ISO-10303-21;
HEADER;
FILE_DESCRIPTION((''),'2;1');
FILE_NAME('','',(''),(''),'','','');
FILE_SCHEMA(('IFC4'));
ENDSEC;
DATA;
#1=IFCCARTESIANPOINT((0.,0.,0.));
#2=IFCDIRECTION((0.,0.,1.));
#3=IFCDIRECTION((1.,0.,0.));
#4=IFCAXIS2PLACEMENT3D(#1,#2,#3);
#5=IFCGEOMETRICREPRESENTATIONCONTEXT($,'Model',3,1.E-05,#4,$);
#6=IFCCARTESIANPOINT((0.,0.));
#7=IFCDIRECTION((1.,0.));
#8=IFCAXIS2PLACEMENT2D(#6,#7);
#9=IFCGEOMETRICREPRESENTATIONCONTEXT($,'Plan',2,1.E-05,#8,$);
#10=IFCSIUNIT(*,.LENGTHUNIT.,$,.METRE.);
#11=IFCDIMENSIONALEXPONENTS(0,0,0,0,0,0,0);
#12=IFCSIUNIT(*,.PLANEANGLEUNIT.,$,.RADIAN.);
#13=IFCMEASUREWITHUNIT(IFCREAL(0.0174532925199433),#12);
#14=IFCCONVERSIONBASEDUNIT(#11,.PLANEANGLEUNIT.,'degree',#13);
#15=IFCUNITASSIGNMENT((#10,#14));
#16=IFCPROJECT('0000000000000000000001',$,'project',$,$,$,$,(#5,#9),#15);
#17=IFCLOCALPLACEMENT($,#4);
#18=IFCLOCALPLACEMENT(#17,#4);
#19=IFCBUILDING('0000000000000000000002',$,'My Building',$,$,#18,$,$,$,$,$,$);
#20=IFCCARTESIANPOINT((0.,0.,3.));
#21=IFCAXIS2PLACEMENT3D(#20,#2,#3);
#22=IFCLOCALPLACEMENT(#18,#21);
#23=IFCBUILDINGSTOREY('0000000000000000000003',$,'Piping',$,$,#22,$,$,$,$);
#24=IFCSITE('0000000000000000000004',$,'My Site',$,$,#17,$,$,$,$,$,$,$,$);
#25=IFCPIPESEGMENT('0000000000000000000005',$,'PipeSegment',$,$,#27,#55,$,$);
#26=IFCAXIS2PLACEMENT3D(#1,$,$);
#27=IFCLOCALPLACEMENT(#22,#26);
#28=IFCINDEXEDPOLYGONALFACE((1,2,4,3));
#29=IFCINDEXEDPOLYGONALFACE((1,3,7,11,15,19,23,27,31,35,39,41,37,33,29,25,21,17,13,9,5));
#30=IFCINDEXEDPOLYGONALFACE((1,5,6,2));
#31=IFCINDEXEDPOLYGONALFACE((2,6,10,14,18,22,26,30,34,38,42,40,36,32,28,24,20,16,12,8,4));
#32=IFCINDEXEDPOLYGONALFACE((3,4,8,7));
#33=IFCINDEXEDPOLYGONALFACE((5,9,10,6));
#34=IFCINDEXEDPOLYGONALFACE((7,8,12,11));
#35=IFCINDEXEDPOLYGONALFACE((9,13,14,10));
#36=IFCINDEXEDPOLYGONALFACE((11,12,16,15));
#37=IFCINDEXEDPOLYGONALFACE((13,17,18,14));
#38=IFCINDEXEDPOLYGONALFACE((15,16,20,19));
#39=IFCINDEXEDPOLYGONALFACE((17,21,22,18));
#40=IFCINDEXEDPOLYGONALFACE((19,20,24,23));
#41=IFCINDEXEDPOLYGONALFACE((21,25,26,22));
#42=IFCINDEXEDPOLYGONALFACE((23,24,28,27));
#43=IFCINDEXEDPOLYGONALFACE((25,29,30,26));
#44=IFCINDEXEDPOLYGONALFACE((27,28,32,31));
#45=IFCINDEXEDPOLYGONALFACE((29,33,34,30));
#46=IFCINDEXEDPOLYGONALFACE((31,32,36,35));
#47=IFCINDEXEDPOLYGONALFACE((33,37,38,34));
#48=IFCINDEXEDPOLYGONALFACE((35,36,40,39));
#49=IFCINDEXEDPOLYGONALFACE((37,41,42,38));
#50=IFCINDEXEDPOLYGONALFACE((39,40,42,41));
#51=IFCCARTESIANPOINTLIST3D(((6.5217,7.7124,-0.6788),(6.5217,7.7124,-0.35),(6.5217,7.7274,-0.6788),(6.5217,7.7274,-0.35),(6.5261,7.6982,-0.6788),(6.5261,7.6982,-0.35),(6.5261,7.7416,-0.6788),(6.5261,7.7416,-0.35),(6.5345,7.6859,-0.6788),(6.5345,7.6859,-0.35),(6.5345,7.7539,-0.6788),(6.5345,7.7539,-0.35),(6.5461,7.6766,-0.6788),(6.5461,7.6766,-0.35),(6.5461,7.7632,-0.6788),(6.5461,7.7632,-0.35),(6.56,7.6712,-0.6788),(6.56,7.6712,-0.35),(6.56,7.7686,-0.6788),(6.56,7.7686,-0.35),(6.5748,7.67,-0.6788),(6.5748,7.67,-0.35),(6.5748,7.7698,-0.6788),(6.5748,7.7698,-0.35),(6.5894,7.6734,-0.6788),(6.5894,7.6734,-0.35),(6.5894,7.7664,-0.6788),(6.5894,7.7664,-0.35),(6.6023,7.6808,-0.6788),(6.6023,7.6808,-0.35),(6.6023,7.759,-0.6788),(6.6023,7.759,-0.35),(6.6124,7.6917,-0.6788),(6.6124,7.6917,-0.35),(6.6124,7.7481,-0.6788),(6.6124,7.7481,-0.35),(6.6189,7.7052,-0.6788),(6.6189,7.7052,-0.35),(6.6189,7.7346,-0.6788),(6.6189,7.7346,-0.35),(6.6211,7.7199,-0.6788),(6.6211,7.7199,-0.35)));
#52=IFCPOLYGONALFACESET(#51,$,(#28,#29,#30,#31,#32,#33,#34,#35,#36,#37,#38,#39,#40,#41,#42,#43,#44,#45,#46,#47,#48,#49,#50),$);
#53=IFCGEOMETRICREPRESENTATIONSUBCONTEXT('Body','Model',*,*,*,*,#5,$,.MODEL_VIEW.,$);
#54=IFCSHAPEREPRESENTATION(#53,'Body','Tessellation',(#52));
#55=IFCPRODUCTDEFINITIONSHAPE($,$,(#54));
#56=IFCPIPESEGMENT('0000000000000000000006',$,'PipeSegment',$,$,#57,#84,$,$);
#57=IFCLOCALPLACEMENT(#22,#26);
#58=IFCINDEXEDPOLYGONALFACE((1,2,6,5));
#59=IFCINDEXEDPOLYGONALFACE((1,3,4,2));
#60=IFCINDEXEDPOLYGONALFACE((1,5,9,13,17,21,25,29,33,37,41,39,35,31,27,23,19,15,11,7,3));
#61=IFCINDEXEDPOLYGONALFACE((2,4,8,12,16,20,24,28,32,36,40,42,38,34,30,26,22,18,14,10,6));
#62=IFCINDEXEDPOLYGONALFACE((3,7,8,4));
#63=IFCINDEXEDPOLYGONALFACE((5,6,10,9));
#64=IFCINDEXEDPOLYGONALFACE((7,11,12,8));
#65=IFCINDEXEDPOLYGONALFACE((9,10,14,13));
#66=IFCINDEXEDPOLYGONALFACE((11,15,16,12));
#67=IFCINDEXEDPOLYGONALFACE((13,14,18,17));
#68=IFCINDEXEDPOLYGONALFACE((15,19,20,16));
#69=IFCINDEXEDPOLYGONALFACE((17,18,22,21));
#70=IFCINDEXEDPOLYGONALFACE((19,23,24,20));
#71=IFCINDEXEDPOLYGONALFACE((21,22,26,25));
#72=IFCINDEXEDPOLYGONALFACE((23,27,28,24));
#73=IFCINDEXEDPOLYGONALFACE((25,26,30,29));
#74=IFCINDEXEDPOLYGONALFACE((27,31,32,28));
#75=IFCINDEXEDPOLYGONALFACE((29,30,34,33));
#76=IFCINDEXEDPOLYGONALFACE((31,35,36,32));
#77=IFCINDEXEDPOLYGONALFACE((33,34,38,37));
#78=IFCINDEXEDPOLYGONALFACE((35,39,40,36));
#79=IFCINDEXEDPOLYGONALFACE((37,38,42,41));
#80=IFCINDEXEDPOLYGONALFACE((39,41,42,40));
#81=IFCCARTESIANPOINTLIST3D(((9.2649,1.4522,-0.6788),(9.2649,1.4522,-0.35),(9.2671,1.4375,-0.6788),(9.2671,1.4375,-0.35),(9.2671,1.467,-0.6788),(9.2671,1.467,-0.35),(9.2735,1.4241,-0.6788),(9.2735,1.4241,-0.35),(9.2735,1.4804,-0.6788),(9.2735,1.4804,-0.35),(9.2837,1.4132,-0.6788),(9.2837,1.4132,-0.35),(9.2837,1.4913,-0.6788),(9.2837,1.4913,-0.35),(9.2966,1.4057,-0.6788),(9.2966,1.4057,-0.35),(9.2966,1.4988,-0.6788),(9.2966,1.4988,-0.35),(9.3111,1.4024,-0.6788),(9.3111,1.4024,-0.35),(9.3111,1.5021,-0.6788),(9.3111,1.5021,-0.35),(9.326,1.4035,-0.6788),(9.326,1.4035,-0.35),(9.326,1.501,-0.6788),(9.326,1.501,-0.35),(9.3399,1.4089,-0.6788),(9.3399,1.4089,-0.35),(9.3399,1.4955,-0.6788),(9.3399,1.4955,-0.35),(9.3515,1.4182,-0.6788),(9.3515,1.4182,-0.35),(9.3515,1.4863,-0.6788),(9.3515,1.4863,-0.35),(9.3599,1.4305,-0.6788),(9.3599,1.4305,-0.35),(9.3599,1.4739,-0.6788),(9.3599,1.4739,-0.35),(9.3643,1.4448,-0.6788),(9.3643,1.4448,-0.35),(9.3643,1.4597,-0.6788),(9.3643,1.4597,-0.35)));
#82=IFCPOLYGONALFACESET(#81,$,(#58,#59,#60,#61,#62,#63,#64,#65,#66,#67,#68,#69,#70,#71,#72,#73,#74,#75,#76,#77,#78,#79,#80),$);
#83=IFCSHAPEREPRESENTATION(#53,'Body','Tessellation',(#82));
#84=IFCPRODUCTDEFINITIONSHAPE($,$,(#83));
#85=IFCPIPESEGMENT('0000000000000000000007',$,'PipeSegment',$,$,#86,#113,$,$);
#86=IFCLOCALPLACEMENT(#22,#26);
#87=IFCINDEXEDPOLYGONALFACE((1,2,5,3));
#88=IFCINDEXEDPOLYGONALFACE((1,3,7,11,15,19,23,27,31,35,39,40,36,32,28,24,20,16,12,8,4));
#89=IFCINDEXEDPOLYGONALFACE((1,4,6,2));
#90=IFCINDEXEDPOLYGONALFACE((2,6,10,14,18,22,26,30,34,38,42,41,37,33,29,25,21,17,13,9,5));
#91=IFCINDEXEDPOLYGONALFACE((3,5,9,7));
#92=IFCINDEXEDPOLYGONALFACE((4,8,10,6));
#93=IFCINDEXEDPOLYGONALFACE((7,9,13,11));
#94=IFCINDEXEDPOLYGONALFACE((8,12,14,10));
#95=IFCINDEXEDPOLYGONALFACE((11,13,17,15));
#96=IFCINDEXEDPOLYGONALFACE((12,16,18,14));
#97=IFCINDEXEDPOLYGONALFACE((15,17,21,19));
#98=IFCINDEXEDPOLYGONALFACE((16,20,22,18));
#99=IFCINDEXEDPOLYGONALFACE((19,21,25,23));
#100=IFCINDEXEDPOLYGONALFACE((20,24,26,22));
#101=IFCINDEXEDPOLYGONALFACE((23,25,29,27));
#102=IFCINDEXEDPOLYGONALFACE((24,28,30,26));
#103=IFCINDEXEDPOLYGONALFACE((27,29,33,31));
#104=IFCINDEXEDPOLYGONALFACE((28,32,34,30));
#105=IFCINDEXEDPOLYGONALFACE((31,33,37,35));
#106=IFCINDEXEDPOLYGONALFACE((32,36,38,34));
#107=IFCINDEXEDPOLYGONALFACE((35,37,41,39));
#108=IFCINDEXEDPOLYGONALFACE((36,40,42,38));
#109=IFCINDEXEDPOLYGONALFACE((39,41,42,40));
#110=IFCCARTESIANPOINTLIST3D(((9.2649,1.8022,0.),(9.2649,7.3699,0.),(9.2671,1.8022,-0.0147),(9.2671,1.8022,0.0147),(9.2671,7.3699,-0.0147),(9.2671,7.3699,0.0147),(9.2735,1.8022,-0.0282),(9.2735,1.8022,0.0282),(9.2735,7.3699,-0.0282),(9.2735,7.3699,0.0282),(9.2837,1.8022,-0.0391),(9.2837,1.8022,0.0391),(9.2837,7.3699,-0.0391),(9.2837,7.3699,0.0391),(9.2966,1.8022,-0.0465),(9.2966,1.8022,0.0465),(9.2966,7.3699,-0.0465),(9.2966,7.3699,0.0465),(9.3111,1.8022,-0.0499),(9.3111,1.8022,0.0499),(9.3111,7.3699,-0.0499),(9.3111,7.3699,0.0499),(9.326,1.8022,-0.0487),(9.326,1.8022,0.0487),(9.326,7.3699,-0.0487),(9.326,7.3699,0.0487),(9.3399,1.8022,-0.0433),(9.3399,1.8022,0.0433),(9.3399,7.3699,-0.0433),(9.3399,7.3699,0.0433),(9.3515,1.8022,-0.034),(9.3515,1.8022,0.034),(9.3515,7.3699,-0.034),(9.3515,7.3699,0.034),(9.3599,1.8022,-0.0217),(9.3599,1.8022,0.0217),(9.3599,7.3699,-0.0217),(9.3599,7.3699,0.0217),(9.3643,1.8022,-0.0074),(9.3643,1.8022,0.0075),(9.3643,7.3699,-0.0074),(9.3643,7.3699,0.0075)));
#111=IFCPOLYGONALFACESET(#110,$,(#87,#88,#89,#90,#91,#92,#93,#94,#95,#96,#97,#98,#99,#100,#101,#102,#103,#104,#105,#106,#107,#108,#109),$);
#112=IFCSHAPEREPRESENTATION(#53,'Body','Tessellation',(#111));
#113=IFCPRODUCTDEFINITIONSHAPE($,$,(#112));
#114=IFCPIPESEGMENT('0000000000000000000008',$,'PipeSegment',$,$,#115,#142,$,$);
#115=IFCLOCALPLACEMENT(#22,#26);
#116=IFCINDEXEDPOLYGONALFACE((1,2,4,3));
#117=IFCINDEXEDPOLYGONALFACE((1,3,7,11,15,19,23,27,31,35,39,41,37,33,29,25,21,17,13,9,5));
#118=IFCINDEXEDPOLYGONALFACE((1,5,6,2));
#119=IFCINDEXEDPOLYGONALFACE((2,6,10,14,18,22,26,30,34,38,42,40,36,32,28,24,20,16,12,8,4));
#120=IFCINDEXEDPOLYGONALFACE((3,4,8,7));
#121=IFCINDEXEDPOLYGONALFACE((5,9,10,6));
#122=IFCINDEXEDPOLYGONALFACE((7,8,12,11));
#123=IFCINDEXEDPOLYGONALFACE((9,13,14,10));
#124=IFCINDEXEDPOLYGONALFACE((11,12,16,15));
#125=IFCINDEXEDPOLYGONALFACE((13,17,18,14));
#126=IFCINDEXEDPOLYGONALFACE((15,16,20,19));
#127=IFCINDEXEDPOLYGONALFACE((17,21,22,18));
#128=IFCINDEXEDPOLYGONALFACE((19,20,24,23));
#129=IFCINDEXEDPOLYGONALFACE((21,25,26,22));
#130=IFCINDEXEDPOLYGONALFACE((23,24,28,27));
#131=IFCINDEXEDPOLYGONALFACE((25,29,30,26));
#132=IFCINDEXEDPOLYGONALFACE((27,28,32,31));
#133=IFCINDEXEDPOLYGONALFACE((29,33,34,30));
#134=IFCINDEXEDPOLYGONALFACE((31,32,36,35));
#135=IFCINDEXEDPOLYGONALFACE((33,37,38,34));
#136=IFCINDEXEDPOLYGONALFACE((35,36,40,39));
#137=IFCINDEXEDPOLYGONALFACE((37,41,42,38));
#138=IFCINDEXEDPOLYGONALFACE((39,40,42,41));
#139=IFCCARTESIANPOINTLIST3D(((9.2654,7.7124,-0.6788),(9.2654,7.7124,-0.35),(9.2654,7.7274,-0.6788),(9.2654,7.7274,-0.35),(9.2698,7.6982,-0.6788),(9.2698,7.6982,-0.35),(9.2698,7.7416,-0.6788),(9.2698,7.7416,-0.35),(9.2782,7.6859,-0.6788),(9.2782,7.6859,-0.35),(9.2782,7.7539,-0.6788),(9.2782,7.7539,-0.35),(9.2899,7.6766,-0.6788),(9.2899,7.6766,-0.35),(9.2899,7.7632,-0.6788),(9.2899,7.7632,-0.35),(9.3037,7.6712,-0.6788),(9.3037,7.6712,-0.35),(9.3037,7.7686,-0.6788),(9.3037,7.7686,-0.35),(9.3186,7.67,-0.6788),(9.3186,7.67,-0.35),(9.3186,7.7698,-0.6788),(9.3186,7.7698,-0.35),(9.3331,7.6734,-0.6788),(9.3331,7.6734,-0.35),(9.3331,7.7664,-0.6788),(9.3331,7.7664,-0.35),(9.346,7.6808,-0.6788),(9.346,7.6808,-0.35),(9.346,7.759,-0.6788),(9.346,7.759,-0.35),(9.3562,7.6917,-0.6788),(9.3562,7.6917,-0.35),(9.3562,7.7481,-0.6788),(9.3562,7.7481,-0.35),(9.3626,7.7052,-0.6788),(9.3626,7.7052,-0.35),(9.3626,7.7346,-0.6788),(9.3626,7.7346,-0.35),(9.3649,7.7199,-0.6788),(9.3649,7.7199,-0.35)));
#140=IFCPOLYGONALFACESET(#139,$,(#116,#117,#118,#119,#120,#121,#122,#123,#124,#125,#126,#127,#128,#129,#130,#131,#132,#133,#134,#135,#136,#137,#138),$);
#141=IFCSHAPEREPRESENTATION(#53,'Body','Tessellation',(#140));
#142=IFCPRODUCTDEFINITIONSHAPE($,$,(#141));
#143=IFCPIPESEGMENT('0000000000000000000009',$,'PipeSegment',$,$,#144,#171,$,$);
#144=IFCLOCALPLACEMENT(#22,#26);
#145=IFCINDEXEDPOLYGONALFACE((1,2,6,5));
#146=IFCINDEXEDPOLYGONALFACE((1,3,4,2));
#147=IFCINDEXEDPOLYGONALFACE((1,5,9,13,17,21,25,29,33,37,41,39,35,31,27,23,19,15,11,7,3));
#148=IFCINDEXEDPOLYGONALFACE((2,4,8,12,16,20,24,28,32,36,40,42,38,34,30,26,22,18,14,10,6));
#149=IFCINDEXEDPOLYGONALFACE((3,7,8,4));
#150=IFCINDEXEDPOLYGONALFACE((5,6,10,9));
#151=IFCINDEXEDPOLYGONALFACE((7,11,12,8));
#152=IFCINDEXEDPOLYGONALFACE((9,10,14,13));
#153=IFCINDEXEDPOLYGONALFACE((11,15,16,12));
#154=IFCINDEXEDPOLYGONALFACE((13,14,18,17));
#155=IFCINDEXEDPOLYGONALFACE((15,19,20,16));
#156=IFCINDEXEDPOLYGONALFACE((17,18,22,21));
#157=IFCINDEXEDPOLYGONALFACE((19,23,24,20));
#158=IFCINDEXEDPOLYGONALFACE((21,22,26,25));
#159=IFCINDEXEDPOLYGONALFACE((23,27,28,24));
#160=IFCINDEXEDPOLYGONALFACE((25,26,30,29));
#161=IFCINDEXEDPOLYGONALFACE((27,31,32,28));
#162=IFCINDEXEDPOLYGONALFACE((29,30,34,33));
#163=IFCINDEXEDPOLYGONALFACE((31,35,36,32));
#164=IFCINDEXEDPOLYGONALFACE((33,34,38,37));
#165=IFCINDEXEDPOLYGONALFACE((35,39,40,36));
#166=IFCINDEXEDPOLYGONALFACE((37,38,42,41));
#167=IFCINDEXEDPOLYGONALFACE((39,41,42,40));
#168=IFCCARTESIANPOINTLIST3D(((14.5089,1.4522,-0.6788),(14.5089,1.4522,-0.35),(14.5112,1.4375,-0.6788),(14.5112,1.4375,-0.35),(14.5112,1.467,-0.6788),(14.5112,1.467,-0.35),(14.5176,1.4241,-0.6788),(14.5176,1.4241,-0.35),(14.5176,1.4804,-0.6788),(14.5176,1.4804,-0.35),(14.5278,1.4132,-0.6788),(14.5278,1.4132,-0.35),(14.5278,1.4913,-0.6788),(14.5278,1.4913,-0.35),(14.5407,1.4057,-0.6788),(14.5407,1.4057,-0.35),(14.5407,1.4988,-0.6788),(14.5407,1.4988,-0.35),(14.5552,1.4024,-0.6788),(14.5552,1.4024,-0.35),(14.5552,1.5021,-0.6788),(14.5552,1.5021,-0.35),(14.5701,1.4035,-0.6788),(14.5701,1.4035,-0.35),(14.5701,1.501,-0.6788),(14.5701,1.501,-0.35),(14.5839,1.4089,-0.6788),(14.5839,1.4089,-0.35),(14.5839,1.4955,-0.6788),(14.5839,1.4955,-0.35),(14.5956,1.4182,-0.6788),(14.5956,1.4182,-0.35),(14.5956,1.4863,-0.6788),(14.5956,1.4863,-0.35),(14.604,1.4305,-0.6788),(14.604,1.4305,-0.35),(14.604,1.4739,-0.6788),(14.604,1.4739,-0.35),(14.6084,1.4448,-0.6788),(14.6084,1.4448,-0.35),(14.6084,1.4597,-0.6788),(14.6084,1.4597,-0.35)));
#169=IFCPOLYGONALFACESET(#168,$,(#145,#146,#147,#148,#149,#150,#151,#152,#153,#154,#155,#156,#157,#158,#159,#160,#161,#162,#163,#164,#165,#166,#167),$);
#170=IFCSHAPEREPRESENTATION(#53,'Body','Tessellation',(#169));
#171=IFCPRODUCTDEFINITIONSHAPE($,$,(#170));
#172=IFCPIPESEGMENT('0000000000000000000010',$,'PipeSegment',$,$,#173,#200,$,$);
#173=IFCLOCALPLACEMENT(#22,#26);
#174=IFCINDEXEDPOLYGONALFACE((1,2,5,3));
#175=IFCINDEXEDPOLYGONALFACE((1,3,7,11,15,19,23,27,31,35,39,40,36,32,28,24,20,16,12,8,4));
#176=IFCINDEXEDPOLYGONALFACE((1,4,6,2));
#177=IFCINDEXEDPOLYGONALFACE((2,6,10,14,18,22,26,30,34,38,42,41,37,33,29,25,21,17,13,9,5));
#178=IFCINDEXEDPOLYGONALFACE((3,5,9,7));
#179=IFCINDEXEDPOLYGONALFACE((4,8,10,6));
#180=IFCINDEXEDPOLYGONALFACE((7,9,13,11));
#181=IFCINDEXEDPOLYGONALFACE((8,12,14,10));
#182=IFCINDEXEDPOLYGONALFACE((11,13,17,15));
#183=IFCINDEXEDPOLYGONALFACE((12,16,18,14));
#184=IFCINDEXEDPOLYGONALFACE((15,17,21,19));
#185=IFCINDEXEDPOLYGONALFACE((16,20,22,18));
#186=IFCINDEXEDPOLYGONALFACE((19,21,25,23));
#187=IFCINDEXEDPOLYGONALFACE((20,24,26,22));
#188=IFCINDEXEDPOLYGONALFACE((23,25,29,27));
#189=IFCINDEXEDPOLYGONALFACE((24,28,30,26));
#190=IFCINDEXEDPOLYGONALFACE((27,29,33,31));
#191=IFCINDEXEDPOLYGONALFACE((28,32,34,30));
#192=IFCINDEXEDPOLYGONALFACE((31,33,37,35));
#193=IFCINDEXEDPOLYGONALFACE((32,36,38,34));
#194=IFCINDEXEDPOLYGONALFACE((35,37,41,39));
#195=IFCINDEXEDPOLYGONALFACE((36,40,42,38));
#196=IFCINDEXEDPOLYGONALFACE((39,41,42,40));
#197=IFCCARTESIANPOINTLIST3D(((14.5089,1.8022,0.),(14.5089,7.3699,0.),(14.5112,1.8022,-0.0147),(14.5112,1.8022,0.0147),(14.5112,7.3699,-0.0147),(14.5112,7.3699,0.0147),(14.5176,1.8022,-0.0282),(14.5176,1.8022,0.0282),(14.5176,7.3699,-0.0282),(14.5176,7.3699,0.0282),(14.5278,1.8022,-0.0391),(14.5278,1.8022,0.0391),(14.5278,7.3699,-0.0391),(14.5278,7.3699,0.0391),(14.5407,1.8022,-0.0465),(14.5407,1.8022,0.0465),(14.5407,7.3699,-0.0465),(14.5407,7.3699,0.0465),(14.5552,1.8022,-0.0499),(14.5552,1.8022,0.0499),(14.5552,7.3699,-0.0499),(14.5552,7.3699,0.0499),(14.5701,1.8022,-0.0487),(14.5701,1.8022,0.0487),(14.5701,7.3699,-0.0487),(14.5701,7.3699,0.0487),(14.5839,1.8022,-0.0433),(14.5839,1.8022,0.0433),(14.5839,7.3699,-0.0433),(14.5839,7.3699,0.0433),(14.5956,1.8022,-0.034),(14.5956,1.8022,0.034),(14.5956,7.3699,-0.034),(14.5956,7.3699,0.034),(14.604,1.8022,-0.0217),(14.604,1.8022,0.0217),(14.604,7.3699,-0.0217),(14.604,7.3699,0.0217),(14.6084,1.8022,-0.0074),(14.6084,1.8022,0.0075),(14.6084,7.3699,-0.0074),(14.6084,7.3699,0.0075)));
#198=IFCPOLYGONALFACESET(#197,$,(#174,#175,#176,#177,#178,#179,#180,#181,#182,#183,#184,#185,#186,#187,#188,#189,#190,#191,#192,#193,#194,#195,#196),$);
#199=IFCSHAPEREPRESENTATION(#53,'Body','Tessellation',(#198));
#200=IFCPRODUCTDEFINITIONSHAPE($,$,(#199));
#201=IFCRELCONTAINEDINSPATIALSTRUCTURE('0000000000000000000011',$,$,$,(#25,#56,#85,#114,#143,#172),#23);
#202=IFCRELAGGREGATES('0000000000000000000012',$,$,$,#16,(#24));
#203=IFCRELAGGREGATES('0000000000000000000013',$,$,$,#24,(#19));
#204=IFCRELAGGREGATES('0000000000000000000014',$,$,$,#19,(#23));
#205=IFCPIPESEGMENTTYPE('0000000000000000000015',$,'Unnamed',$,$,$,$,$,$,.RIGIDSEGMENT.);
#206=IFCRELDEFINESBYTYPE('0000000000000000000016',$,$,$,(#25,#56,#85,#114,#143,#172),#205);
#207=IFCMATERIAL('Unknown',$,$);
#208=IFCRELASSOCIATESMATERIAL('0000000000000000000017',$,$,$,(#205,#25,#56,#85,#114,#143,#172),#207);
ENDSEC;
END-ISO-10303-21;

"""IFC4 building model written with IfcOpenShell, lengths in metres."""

from ifc_helpers import new_model, entity, si_unit, converted_unit, frame, origin_with_axes, origin_2d_with_axis, place, context, subcontext, project, spatial, circle, extrude, material, material_profile, profile_set, profile_usage, type_object, element, save


model = new_model("IFC4")

# Units and contexts
model_context = context("Model", 3, precision=1e-05, world=origin_with_axes())
plan_context = context("Plan", 2, precision=1e-05, world=origin_2d_with_axis())
body_context = subcontext(model_context, "Body", "Model", "MODEL_VIEW")
ifc_project = project(units=[si_unit("LENGTHUNIT", "METRE"), converted_unit("PLANEANGLEUNIT", "degree", entity("IfcReal", 0.0174532925199433), si_unit("PLANEANGLEUNIT", "RADIAN"), dimensions=[0, 0, 0, 0, 0, 0, 0])], contexts=[model_context, plan_context])

# Site, building, storey
site_placement = place(None, origin_with_axes())
site = spatial("IfcSite", under=ifc_project, at=site_placement, Name="My Site")
building_placement = place(site_placement, origin_with_axes())
building = spatial("IfcBuilding", under=site, at=building_placement, Name="My Building")
storey_placement = place(building_placement, frame((0.0, 0.0, 3.0), z_axis=(0.0, 0.0, 1.0), x_axis=(1.0, 0.0, 0.0)))
storey = spatial("IfcBuildingStorey", under=building, at=storey_placement, Name="Piping")

# Pipe segments
ifc_material = material(Name="Unknown")
ifc_material_profile = material_profile(ifc_material, circle(Radius=0.05))
ifc_profile_set = profile_set([ifc_material_profile])
pipe_segment_type = type_object("IfcPipeSegmentType", Name="Unnamed", PredefinedType="RIGIDSEGMENT", material=ifc_profile_set)
ifc_profile_usage_1 = profile_usage(ifc_profile_set, cardinal=5)
pipe_segment_1_placement = place(storey_placement, frame((6.5711, 7.7199, -0.6788), z_axis=(0.0, 0.0, 1.0), x_axis=(1.0, 0.0, 0.0)))
element("IfcPipeSegment", 1, at=pipe_segment_1_placement, inside=storey, type_object=pipe_segment_type, material=ifc_profile_usage_1, Name="PipeSegment", context=body_context, shape_type="SweptSolid", body=[
    extrude(circle(Radius=0.05), origin_with_axes(), (0.0, 0.0, 1.0), 0.3288),
])
ifc_profile_usage_2 = profile_usage(ifc_profile_set, cardinal=5)
pipe_segment_2_placement = place(storey_placement, frame((9.3149, 1.4522, -0.35), z_axis=(0.0, 0.0, -1.0), x_axis=(-1.0, 0.0, 0.0)))
element("IfcPipeSegment", 2, at=pipe_segment_2_placement, inside=storey, type_object=pipe_segment_type, material=ifc_profile_usage_2, Name="PipeSegment", context=body_context, shape_type="SweptSolid", body=[
    extrude(circle(Radius=0.05), origin_with_axes(), (0.0, 0.0, 1.0), 0.3288),
])
ifc_profile_usage_3 = profile_usage(ifc_profile_set, cardinal=5)
pipe_segment_3_placement = place(storey_placement, frame((9.3149, 1.8022, 0.0), z_axis=(0.0, 1.0, 0.0), x_axis=(-1.0, 0.0, 0.0)))
element("IfcPipeSegment", 3, at=pipe_segment_3_placement, inside=storey, type_object=pipe_segment_type, material=ifc_profile_usage_3, Name="PipeSegment", context=body_context, shape_type="SweptSolid", body=[
    extrude(circle(Radius=0.05), origin_with_axes(), (0.0, 0.0, 1.0), 5.5677),
])
ifc_profile_usage_4 = profile_usage(ifc_profile_set, cardinal=5)
pipe_segment_4_placement = place(storey_placement, frame((9.3149, 7.7199, -0.6788), z_axis=(0.0, 0.0, 1.0), x_axis=(1.0, 0.0, 0.0)))
element("IfcPipeSegment", 4, at=pipe_segment_4_placement, inside=storey, type_object=pipe_segment_type, material=ifc_profile_usage_4, Name="PipeSegment", context=body_context, shape_type="SweptSolid", body=[
    extrude(circle(Radius=0.05), origin_with_axes(), (0.0, 0.0, 1.0), 0.3288),
])
ifc_profile_usage_5 = profile_usage(ifc_profile_set, cardinal=5)
pipe_segment_5_placement = place(storey_placement, frame((14.5589, 1.4522, -0.35), z_axis=(0.0, 0.0, -1.0), x_axis=(-1.0, 0.0, 0.0)))
element("IfcPipeSegment", 5, at=pipe_segment_5_placement, inside=storey, type_object=pipe_segment_type, material=ifc_profile_usage_5, Name="PipeSegment", context=body_context, shape_type="SweptSolid", body=[
    extrude(circle(Radius=0.05), origin_with_axes(), (0.0, 0.0, 1.0), 0.3288),
])
ifc_profile_usage_6 = profile_usage(ifc_profile_set, cardinal=5)
pipe_segment_6_placement = place(storey_placement, frame((14.5589, 1.8022, 0.0), z_axis=(0.0, 1.0, 0.0), x_axis=(-1.0, 0.0, 0.0)))
element("IfcPipeSegment", 6, at=pipe_segment_6_placement, inside=storey, type_object=pipe_segment_type, material=ifc_profile_usage_6, Name="PipeSegment", context=body_context, shape_type="SweptSolid", body=[
    extrude(circle(Radius=0.05), origin_with_axes(), (0.0, 0.0, 1.0), 5.5677),
])

save(model, "model.ifc")
